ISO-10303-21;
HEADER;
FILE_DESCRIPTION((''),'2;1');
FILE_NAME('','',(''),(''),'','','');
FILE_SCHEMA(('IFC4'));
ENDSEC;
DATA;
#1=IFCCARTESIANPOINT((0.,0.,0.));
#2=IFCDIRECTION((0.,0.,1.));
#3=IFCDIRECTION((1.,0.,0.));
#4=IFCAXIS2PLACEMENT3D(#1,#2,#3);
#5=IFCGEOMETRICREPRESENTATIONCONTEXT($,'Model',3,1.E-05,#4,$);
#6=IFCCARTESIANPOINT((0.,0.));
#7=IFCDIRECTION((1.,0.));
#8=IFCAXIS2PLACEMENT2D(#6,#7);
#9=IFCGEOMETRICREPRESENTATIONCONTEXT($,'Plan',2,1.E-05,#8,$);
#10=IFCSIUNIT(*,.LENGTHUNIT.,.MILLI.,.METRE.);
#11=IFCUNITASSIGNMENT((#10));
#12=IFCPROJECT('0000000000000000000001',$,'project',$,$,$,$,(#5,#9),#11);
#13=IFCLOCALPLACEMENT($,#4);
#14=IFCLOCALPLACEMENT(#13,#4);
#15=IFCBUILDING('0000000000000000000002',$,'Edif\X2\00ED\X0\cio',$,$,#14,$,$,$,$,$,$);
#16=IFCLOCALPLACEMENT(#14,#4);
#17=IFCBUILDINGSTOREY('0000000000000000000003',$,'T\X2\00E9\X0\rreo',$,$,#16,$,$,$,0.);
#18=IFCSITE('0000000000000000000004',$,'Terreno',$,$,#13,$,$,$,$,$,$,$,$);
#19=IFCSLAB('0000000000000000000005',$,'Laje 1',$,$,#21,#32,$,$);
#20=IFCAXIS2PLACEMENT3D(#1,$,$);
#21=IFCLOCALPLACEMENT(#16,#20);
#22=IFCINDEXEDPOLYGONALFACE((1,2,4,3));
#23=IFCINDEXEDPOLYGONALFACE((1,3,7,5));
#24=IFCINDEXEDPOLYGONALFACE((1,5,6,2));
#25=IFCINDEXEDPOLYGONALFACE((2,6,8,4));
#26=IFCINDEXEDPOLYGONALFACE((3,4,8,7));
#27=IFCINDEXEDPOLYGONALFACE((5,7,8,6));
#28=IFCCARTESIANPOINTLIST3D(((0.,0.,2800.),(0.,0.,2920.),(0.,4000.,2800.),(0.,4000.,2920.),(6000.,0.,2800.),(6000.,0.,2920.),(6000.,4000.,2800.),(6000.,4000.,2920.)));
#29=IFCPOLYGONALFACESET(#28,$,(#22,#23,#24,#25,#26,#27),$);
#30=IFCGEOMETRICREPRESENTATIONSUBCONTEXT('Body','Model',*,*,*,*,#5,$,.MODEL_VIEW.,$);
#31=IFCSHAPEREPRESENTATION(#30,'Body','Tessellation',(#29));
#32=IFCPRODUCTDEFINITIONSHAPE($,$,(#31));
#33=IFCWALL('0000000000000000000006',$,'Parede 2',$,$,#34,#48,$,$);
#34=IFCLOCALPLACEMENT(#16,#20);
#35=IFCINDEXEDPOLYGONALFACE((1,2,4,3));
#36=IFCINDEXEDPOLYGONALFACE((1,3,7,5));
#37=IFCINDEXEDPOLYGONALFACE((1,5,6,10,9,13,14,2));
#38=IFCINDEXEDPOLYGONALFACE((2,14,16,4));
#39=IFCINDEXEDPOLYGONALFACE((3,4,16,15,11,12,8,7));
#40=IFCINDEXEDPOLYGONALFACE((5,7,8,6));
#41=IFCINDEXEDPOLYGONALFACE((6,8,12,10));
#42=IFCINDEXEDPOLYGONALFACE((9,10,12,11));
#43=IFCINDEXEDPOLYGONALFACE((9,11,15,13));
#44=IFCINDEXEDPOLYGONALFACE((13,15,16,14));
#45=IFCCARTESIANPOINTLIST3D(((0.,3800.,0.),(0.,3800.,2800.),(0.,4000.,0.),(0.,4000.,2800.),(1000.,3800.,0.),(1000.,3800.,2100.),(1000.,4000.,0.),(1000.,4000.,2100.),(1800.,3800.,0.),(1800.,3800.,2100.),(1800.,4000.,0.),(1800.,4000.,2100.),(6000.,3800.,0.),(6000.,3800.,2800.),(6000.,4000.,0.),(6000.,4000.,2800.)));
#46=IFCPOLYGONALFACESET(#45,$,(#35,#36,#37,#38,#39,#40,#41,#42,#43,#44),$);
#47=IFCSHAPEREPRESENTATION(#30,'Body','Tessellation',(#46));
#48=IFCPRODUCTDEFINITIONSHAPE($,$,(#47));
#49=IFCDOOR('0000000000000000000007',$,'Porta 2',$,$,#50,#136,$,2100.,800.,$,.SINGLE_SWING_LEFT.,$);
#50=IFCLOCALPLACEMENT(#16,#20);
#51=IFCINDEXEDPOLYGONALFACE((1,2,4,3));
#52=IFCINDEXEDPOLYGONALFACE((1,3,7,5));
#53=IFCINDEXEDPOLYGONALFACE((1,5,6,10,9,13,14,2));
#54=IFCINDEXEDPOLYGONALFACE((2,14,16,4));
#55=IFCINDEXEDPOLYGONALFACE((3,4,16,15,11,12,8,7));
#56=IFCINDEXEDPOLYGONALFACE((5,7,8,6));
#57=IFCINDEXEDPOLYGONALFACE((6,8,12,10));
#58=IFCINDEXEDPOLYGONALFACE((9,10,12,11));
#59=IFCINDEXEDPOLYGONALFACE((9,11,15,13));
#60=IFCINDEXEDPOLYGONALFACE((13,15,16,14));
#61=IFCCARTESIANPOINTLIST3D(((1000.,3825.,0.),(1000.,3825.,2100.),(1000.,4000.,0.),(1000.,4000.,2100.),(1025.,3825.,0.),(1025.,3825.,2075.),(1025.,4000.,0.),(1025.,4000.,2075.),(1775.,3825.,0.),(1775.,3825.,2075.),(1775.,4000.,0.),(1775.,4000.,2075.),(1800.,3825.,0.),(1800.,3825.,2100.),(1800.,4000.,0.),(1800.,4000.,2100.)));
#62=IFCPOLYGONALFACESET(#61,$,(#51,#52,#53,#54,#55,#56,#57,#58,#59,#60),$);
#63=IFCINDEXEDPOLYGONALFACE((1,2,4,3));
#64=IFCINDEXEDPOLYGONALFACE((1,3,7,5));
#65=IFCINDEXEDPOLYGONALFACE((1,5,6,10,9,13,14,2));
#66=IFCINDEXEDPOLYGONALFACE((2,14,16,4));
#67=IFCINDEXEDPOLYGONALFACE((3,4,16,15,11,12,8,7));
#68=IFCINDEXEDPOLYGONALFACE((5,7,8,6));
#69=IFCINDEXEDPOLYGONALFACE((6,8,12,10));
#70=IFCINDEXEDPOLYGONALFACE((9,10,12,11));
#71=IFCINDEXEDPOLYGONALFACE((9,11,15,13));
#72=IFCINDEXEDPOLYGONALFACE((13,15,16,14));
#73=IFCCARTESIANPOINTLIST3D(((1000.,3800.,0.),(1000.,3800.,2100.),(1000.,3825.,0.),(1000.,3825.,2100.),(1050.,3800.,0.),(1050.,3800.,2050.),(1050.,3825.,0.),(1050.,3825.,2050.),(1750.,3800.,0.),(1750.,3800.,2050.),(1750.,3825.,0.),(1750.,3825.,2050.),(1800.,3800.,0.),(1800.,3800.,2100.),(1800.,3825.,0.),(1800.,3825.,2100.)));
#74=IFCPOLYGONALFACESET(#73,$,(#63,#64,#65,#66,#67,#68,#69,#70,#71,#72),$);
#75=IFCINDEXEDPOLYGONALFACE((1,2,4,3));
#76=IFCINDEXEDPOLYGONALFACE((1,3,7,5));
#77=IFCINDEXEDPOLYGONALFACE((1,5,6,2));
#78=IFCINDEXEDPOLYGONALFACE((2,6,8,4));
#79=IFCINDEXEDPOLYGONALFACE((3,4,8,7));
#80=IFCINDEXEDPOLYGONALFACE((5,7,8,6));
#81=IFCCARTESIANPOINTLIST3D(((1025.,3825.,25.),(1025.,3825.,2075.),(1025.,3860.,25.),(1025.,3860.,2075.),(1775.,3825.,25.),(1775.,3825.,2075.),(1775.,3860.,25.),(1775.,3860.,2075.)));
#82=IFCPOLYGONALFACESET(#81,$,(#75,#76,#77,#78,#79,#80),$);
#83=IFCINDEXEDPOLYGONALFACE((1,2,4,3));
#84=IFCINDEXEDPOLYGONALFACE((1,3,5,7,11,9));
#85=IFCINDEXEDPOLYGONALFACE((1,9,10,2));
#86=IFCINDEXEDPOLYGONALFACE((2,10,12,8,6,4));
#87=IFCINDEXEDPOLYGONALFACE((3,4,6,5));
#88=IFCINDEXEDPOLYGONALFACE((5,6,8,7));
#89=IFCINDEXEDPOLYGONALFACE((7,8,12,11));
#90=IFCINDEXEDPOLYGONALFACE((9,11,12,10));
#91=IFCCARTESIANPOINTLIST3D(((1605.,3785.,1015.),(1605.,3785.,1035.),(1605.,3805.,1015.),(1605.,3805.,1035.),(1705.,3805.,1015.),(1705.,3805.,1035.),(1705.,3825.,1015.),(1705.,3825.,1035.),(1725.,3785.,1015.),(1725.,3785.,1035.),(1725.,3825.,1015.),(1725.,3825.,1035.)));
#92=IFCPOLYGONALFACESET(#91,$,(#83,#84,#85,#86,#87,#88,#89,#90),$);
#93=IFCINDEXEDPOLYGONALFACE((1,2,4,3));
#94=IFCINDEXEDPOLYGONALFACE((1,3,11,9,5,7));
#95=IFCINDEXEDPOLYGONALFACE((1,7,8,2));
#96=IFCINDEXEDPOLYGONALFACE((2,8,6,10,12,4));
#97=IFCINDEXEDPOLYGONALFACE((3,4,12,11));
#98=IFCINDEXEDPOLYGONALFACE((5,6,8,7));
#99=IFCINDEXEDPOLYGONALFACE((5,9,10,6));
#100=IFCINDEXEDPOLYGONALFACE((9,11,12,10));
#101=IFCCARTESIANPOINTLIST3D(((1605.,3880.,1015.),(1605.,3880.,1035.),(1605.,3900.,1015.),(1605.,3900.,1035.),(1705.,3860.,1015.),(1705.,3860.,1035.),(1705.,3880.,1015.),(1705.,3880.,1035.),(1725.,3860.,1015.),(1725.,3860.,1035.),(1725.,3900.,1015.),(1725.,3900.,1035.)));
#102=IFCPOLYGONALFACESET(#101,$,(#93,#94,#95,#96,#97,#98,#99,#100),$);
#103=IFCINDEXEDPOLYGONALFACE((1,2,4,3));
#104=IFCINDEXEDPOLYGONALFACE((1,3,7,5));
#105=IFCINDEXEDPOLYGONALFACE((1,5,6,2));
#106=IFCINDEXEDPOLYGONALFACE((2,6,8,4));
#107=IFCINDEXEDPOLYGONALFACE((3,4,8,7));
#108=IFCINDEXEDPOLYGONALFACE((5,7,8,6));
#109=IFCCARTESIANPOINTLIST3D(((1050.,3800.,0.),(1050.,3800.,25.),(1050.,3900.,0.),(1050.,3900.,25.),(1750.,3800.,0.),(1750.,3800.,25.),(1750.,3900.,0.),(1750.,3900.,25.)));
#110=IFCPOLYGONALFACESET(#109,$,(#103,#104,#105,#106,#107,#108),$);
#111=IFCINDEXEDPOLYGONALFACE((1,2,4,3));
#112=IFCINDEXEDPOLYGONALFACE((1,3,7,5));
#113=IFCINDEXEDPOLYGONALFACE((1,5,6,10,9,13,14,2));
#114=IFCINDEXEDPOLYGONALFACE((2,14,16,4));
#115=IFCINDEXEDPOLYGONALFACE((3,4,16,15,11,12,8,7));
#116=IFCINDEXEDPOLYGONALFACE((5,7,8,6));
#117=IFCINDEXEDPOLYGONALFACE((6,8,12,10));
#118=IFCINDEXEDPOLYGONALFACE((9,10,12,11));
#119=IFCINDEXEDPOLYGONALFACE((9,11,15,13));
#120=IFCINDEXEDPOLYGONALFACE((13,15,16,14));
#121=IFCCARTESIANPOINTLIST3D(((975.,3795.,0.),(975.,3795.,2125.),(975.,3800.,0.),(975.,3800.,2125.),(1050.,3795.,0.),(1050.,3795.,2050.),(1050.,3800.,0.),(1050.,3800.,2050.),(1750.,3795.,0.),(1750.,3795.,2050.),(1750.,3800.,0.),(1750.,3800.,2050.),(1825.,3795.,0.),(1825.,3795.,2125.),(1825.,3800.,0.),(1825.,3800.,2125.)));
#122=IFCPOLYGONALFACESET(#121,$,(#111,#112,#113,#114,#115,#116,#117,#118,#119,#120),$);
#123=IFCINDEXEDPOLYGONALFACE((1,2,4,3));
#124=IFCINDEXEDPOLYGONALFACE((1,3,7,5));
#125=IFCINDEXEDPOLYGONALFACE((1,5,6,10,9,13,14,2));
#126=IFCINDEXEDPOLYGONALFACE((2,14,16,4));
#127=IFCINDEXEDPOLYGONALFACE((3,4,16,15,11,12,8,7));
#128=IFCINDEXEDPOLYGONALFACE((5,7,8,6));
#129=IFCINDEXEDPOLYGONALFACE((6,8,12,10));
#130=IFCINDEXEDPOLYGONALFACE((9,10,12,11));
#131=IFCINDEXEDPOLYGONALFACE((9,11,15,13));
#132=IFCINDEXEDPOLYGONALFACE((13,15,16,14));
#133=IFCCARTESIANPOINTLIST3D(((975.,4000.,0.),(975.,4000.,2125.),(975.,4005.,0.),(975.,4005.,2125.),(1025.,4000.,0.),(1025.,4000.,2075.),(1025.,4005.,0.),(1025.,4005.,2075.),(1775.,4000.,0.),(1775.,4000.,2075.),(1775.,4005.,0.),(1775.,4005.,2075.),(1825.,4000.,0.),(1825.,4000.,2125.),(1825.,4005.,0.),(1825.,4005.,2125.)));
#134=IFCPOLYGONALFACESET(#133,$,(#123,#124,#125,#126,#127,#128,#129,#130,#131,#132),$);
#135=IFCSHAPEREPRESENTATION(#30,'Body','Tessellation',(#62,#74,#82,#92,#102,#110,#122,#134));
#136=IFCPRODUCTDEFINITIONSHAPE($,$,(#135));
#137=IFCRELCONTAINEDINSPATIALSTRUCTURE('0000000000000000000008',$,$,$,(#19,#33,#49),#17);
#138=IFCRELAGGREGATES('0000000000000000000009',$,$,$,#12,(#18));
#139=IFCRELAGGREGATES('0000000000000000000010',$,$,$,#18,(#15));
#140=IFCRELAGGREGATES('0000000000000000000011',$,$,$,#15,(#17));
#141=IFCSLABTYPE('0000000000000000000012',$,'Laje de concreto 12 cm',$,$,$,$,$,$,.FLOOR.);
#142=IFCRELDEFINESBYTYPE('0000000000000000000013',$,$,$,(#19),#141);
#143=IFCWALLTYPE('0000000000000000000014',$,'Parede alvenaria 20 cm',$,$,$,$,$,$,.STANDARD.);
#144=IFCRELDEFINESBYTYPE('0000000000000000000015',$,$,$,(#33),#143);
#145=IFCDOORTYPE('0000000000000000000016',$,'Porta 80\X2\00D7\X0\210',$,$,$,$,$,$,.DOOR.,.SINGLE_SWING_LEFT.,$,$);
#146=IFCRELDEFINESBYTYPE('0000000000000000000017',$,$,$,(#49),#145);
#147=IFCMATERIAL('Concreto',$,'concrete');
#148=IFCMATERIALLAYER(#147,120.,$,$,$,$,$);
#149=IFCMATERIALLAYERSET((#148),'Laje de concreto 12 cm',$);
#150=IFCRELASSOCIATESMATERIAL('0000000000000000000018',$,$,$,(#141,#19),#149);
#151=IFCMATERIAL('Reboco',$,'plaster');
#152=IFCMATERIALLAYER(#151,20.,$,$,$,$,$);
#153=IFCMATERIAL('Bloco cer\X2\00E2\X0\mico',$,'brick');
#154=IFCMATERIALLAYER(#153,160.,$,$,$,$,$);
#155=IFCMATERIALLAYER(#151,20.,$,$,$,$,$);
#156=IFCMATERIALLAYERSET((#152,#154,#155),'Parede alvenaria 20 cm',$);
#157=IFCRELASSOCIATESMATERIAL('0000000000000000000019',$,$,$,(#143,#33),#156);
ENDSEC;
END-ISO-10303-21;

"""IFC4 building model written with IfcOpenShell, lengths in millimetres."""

from ifc_helpers import new_model, entity, si_unit, frame, origin_with_axes, origin_2d_with_axis, place, context, subcontext, project, spatial, line, indexed_curve, outline, extrude, shape, material, layer, layer_set, layer_usage, type_object, element, fill, save


model = new_model("IFC4")

# Units and contexts
model_context = context("Model", 3, precision=1e-05, world=origin_with_axes())
plan_context = context("Plan", 2, precision=1e-05, world=origin_2d_with_axis())
body_context_1 = subcontext(model_context, "Body", "Model", "MODEL_VIEW")
body_context_2 = subcontext(plan_context, "Body", "Plan", "PLAN_VIEW")
ifc_project = project(units=[si_unit("LENGTHUNIT", "METRE", prefix="MILLI")], contexts=[model_context, plan_context])

# Site, building, storey
site_placement = place(None, origin_with_axes())
site = spatial("IfcSite", under=ifc_project, at=site_placement, Name="Terreno")
building_placement = place(site_placement, origin_with_axes())
building = spatial("IfcBuilding", under=site, at=building_placement, Name="Edifício")
storey_placement = place(building_placement, origin_with_axes())
storey = spatial("IfcBuildingStorey", under=building, at=storey_placement, Name="Térreo", Elevation=0.0)

# Slab
ifc_material_1 = material(Name="Concreto", Category="concrete")
ifc_layer_1 = layer(ifc_material_1, 120.0)
ifc_layer_set_1 = layer_set([ifc_layer_1], Name="Laje de concreto 12 cm")
ifc_layer_usage_1 = layer_usage(ifc_layer_set_1, "AXIS3", "POSITIVE", 0.0)
slab_type = type_object("IfcSlabType", Name="Laje de concreto 12 cm", PredefinedType="FLOOR", material=ifc_layer_set_1)
slab_placement = place(storey_placement, frame((0.0, 0.0, 2800.0), z_axis=(0.0, 0.0, 1.0), x_axis=(1.0, 0.0, 0.0)))
element("IfcSlab", 1, at=slab_placement, inside=storey, type_object=slab_type, material=ifc_layer_usage_1, Name="Laje 1", context=body_context_1, shape_type="SweptSolid", body=[
    extrude(outline(indexed_curve([(0.0, 0.0), (6000.0, 0.0), (6000.0, 4000.0), (0.0, 4000.0)])), None, (0.0, 0.0, 1.0), 120.0),
])

# Shared definitions
ifc_material_2 = material(Name="Reboco", Category="plaster")
ifc_layer_2 = layer(ifc_material_2, 20.0)
ifc_material_3 = material(Name="Bloco cerâmico", Category="brick")
ifc_layer_3 = layer(ifc_material_3, 160.0)
ifc_layer_4 = layer(ifc_material_2, 20.0)
ifc_layer_set_2 = layer_set([ifc_layer_2, ifc_layer_3, ifc_layer_4], Name="Parede alvenaria 20 cm")
wall_type = type_object("IfcWallType", Name="Parede alvenaria 20 cm", PredefinedType="STANDARD", material=ifc_layer_set_2)

# Wall, opening, door
ifc_layer_usage_2 = layer_usage(ifc_layer_set_2, "AXIS2", "POSITIVE", -100.0)
wall_1_placement = place(storey_placement, frame((0.0, 3900.0, 0.0), z_axis=(0.0, 0.0, 1.0), x_axis=(1.0, 0.0, 0.0)))
wall_1 = element("IfcWall", 2, at=wall_1_placement, inside=storey, type_object=wall_type, material=ifc_layer_usage_2, Name="Parede 2", context=body_context_1, shape_type="SweptSolid", body=[
    extrude(outline(indexed_curve([(0.0, 0.0), (0.0, 200.0), (6000.0, 200.0), (6000.0, 0.0), (0.0, 0.0)], self_intersect=False)), frame((0.0, -100.0, 0.0), z_axis=(0.0, 0.0, 1.0), x_axis=(1.0, 0.0, 0.0)), (0.0, 0.0, 1.0), 2800.0),
])
opening_1_placement = place(wall_1_placement, frame((1000.0, -110.0, 0.0), z_axis=(0.0, 0.0, 1.0), x_axis=(1.0, 0.0, 0.0)))
opening_1 = element("IfcOpeningElement", 3, at=opening_1_placement, cuts=wall_1, context=body_context_1, shape_type="SweptSolid", body=[
    extrude(outline(indexed_curve([(0.0, 0.0), (0.0, 220.0), (800.0, 220.0), (800.0, 0.0), (0.0, 0.0)], self_intersect=False)), origin_with_axes(), (0.0, 0.0, 1.0), 2100.0),
])
door_type_1 = type_object("IfcDoorType", Name="Porta 80×210", OperationType="SINGLE_SWING_LEFT", PredefinedType="DOOR")
door_1_placement = place(opening_1_placement, frame((0.0, 10.0, 0.0), z_axis=(0.0, 0.0, 1.0), x_axis=(1.0, 0.0, 0.0)))
door_1 = element("IfcDoor", 4, at=door_1_placement, inside=storey, type_object=door_type_1, Name="Porta 2", OperationType="SINGLE_SWING_LEFT", OverallHeight=2100.0, OverallWidth=800.0, shapes=[
    shape(body_context_1, "Body", "SweptSolid", [extrude(outline(indexed_curve([(0.0, 0.0), (0.0, 2100.0), (800.0, 2100.0), (800.0, 0.0), (775.0, 0.0), (775.0, 2075.0), (25.0, 2075.0), (25.0, 0.0)], segments=[line(1, 2, 3, 4, 5, 6, 7, 8, 1)])), frame((0.0, 25.0, 0.0), z_axis=(0.0, -1.0, 0.0), x_axis=(1.0, 0.0, 0.0)), (0.0, 0.0, -1.0), 175.0), extrude(outline(indexed_curve([(0.0, 0.0), (0.0, 2100.0), (800.0, 2100.0), (800.0, 0.0), (750.0, 0.0), (750.0, 2050.0), (50.0, 2050.0), (50.0, 0.0)], segments=[line(1, 2, 3, 4, 5, 6, 7, 8, 1)])), frame((0.0, 0.0, 0.0), z_axis=(0.0, -1.0, 0.0), x_axis=(1.0, 0.0, 0.0)), (0.0, 0.0, -1.0), 25.0), extrude(outline(indexed_curve([(0.0, 0.0), (750.0, 0.0), (750.0, 35.0), (0.0, 35.0)], segments=[line(1, 2, 3, 4, 1)])), frame((25.0, 25.0, 25.0), z_axis=(0.0, 0.0, 1.0), x_axis=(1.0, 0.0, 0.0)), (0.0, 0.0, 1.0), 2050.0), extrude(outline(indexed_curve([(0.0, 0.0), (0.0, -40.0), (-120.0, -40.0), (-120.0, -20.0), (-20.0, -20.0), (-20.0, 0.0)], segments=[line(1, 2, 3, 4, 5, 6, 1)])), frame((725.0, 25.0, 1015.0), z_axis=(0.0, 0.0, 1.0), x_axis=(1.0, 0.0, 0.0)), (0.0, 0.0, 1.0), 20.0), extrude(outline(indexed_curve([(0.0, 0.0), (0.0, 40.0), (-120.0, 40.0), (-120.0, 20.0), (-20.0, 20.0), (-20.0, 0.0)], segments=[line(1, 2, 3, 4, 5, 6, 1)])), frame((725.0, 60.0, 1015.0), z_axis=(0.0, 0.0, 1.0), x_axis=(1.0, 0.0, 0.0)), (0.0, 0.0, 1.0), 20.0), extrude(outline(indexed_curve([(0.0, 0.0), (700.0, 0.0), (700.0, 100.0), (0.0, 100.0)], segments=[line(1, 2, 3, 4, 1)])), frame((50.0, 0.0, 0.0), z_axis=(0.0, 0.0, 1.0), x_axis=(1.0, 0.0, 0.0)), (0.0, 0.0, 1.0), 25.0), extrude(outline(indexed_curve([(0.0, 0.0), (0.0, 2125.0), (850.0, 2125.0), (850.0, 0.0), (775.0, 0.0), (775.0, 2050.0), (75.0, 2050.0), (75.0, 0.0)], segments=[line(1, 2, 3, 4, 5, 6, 7, 8, 1)])), frame((-25.0, -5.0, 0.0), z_axis=(0.0, -1.0, 0.0), x_axis=(1.0, 0.0, 0.0)), (0.0, 0.0, -1.0), 5.0), extrude(outline(indexed_curve([(0.0, 0.0), (0.0, 2125.0), (850.0, 2125.0), (850.0, 0.0), (800.0, 0.0), (800.0, 2075.0), (50.0, 2075.0), (50.0, 0.0)], segments=[line(1, 2, 3, 4, 5, 6, 7, 8, 1)])), frame((-25.0, 200.0, 0.0), z_axis=(0.0, -1.0, 0.0), x_axis=(1.0, 0.0, 0.0)), (0.0, 0.0, -1.0), 5.0)]),
    shape(body_context_2, "Body", "Curve2D", [entity("IfcIndexedPolyCurve", entity("IfcCartesianPointList2D", [[0.0, 0.0], [0.0, 200.0], [25.0, 200.0], [25.0, 25.0], [50.0, 25.0], [50.0, 0.0]]), [entity("IfcLineIndex", [1, 2, 3, 4, 5, 6, 1])]), entity("IfcIndexedPolyCurve", entity("IfcCartesianPointList2D", [[800.0, 0.0], [800.0, 200.0], [775.0, 200.0], [775.0, 25.0], [750.0, 25.0], [750.0, 0.0]]), [entity("IfcLineIndex", [1, 2, 3, 4, 5, 6, 1])]), entity("IfcTrimmedCurve", entity("IfcEllipse", entity("IfcAxis2Placement2D", entity("IfcCartesianPoint", [60.0, 200.0]), entity("IfcDirection", [1.0, 0.0])), 715.0, 750.0), [entity("IfcCartesianPoint", [775.0, 200.0])], [entity("IfcCartesianPoint", [60.0, 950.0])], True, "CARTESIAN"), entity("IfcIndexedPolyCurve", entity("IfcCartesianPointList2D", [[25.0, 200.0], [60.0, 200.0], [60.0, 950.0], [25.0, 950.0]]), [entity("IfcLineIndex", [1, 2, 3, 4, 1])])]),
])
fill(opening_1, door_1)

save(model, "model.ifc")
